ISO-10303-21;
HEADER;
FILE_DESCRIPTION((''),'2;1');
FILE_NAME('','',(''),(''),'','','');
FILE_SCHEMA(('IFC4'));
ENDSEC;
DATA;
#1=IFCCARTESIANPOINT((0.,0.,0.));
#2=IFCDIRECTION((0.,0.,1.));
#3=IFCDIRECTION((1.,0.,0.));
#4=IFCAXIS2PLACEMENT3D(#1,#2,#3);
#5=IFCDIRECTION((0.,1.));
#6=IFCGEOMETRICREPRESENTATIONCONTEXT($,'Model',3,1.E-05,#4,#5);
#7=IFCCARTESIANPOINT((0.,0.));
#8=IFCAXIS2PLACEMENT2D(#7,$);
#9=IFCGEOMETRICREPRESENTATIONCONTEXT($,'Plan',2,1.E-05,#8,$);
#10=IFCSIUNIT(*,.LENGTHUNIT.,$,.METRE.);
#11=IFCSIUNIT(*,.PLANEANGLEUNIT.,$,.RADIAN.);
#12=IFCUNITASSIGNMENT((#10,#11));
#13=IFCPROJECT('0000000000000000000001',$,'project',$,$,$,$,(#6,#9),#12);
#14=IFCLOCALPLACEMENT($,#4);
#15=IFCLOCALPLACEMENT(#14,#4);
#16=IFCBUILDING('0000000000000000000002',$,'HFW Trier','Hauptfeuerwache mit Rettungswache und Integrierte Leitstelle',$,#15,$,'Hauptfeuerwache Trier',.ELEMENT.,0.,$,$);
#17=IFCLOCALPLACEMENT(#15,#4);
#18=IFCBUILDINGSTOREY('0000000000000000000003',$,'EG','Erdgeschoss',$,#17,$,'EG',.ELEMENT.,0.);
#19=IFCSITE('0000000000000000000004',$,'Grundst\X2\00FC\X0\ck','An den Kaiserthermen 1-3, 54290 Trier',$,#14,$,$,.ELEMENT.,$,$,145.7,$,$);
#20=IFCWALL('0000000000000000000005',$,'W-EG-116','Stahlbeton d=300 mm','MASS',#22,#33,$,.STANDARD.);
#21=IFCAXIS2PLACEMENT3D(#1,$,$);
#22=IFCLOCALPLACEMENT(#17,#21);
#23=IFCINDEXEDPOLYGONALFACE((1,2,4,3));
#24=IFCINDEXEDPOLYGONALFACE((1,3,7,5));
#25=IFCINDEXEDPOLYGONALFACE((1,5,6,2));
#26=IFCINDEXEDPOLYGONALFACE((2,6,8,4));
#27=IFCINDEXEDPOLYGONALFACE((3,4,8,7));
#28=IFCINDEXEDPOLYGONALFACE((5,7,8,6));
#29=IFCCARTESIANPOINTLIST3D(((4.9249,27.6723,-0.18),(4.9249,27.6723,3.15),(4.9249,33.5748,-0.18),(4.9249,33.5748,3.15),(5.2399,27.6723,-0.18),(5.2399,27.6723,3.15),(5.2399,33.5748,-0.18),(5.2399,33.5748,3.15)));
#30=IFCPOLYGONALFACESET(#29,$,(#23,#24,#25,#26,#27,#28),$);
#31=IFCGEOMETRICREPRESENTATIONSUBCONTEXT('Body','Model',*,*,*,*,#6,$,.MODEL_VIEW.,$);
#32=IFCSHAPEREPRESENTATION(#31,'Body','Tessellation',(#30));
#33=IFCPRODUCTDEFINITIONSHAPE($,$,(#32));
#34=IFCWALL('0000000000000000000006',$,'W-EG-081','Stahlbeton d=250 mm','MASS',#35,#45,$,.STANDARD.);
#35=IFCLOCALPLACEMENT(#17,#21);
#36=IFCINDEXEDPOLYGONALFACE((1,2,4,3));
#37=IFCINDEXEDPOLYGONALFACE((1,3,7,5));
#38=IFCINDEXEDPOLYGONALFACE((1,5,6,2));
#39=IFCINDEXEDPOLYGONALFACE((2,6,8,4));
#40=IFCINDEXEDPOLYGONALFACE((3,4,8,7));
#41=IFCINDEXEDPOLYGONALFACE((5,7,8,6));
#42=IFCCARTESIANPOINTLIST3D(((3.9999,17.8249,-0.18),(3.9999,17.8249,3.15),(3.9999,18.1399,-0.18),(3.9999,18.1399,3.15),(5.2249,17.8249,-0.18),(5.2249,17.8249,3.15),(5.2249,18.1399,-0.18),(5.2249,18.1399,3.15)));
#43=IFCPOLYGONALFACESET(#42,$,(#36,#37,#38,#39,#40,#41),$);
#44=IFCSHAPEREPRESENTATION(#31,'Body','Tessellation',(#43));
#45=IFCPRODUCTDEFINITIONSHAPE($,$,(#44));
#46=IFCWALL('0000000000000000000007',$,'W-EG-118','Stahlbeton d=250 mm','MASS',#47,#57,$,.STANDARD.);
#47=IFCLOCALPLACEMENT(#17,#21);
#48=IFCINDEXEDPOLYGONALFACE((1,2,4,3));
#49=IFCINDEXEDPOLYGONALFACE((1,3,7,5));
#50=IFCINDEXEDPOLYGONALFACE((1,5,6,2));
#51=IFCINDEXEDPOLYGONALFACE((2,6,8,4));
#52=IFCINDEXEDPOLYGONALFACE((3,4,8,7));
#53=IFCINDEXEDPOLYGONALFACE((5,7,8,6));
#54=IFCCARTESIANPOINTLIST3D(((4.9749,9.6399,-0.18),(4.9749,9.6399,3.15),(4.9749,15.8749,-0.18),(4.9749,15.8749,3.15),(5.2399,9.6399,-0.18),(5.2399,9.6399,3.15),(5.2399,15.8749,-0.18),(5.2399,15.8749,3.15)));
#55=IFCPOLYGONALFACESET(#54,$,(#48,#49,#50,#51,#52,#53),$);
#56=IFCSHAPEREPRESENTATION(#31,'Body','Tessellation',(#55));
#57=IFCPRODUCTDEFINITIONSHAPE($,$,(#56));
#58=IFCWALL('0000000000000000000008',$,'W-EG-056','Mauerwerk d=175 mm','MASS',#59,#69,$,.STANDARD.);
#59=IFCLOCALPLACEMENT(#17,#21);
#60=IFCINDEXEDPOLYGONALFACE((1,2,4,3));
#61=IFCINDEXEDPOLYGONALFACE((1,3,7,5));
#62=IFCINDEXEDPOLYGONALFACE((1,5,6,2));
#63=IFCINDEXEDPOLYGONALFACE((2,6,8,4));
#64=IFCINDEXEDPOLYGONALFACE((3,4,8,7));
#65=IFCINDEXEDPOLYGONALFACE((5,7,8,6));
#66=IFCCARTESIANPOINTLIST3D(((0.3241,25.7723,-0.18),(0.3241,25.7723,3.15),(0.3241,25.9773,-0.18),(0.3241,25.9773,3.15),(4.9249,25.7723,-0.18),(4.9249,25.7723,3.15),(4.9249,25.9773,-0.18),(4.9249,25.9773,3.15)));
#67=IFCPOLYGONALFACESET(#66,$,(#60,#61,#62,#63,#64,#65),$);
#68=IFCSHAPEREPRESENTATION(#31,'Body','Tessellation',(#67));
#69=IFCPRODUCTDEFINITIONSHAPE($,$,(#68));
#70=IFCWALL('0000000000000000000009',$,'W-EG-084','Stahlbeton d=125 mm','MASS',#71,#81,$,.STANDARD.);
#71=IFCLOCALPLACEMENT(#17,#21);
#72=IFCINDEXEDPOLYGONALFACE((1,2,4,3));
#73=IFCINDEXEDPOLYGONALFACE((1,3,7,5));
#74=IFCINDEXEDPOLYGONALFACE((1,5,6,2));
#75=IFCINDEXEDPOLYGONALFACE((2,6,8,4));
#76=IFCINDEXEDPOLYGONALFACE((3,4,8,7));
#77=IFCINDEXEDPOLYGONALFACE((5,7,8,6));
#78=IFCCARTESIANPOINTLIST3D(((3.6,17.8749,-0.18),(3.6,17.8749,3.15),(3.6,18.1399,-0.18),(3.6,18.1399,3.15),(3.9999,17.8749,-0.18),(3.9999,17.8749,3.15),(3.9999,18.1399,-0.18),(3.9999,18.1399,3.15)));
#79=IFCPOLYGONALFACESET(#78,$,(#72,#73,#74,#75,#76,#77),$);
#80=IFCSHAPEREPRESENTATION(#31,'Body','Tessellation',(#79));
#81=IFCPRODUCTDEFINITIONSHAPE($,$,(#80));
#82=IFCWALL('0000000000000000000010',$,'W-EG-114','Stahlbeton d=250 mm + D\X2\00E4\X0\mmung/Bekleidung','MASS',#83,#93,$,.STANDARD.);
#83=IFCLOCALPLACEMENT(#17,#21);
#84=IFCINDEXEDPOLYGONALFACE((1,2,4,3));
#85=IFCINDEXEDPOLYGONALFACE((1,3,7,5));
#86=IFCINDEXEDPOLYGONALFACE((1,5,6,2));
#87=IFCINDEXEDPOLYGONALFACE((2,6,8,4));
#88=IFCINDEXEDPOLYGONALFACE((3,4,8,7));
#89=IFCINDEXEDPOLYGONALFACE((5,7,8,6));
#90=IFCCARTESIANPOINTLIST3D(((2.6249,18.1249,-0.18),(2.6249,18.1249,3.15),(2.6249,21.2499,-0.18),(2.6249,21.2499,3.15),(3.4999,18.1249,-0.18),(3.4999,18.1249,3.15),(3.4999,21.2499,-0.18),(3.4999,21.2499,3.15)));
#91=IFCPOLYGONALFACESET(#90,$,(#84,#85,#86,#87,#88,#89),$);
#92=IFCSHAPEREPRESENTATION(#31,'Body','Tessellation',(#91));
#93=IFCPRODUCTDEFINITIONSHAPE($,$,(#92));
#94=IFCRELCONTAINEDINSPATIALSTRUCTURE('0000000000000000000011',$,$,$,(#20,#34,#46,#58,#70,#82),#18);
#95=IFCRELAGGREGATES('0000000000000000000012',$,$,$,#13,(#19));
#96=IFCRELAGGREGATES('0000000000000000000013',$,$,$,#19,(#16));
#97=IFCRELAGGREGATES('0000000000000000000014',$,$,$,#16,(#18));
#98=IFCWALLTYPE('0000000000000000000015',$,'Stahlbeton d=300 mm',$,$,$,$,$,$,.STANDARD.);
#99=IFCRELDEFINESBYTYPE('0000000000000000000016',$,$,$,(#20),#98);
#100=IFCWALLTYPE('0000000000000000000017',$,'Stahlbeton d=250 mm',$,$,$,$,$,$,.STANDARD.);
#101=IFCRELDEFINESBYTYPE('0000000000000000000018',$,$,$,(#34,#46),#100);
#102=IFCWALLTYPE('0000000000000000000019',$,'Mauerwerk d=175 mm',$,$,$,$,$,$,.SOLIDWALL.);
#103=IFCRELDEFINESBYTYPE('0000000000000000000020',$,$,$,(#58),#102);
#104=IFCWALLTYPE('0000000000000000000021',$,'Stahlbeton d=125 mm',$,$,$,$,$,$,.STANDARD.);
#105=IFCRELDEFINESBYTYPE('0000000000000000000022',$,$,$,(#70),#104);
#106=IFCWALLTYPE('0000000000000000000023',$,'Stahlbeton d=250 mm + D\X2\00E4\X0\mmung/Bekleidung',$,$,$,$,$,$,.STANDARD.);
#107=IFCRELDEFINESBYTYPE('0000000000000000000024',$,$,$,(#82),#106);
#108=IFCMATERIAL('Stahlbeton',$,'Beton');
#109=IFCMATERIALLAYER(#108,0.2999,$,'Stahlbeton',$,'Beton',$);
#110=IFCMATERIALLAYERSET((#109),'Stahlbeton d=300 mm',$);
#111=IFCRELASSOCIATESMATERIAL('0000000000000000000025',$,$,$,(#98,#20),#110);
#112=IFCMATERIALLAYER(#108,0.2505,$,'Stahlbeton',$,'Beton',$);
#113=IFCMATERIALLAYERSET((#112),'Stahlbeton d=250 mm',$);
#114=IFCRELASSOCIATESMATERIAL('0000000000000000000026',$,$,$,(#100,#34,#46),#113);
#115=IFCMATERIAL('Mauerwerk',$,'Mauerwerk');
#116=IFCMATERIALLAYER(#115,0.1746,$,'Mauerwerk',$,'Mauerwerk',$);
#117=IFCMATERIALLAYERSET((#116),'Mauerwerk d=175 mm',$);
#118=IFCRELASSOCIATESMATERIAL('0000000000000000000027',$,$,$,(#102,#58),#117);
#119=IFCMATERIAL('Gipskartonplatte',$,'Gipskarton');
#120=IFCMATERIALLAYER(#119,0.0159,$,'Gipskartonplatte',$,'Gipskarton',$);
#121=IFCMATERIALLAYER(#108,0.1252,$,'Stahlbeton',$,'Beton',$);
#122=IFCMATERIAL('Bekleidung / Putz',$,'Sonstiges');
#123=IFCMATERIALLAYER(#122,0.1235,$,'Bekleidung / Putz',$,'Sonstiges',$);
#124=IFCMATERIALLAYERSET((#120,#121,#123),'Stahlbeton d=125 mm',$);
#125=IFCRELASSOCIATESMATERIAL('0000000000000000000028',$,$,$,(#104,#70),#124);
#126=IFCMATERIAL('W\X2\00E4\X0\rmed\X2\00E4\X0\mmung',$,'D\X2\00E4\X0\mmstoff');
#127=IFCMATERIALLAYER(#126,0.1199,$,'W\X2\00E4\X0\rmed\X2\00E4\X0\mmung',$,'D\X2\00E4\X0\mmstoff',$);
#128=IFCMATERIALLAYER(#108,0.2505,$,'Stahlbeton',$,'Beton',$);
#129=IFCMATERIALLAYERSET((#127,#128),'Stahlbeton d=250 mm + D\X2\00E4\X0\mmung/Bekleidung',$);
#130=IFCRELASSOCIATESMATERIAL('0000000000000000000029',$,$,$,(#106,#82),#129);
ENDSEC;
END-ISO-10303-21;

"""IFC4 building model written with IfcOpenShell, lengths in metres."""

from ifc_helpers import new_model, si_unit, direction, frame, frame_2d, origin_with_axes, origin_2d, place, context, subcontext, project, spatial, rectangle, extrude, material, layer, layer_set, layer_usage, type_object, element, save


model = new_model("IFC4")

# Units and contexts
model_context = context("Model", 3, precision=1e-05, world=origin_with_axes(), true_north=direction((0.0, 1.0)))
plan_context = context("Plan", 2, precision=1e-05, world=origin_2d())
body_context = subcontext(model_context, "Body", "Model", "MODEL_VIEW")
ifc_project = project(units=[si_unit("LENGTHUNIT", "METRE"), si_unit("PLANEANGLEUNIT", "RADIAN")], contexts=[model_context, plan_context])

# Site, building, storey
site_placement = place(None, origin_with_axes())
site = spatial("IfcSite", under=ifc_project, at=site_placement, Name="Grundstück", Description="An den Kaiserthermen 1-3, 54290 Trier", CompositionType="ELEMENT", RefElevation=145.7)
building_placement = place(site_placement, origin_with_axes())
building = spatial("IfcBuilding", under=site, at=building_placement, Name="HFW Trier", Description="Hauptfeuerwache mit Rettungswache und Integrierte Leitstelle", LongName="Hauptfeuerwache Trier", CompositionType="ELEMENT", ElevationOfRefHeight=0.0)
storey_placement = place(building_placement, origin_with_axes())
storey = spatial("IfcBuildingStorey", under=building, at=storey_placement, Name="EG", Description="Erdgeschoss", LongName="EG", CompositionType="ELEMENT", Elevation=0.0)

# Shared definitions
ifc_material_1 = material(Name="Stahlbeton", Category="Beton")
ifc_layer_1 = layer(ifc_material_1, 0.2999, Name="Stahlbeton", Category="Beton")
ifc_layer_set_1 = layer_set([ifc_layer_1], Name="Stahlbeton d=300 mm")
wall_type_1 = type_object("IfcWallType", Name="Stahlbeton d=300 mm", PredefinedType="STANDARD", material=ifc_layer_set_1)

# Walls
ifc_layer_usage_1 = layer_usage(ifc_layer_set_1, "AXIS2", "POSITIVE", -0.1575)
wall_1_placement = place(storey_placement, frame((5.0824, 33.5748, -0.18), z_axis=(0.0, 0.0, 1.0), x_axis=(0.0, -1.0, 0.0)))
element("IfcWall", 1, at=wall_1_placement, inside=storey, type_object=wall_type_1, material=ifc_layer_usage_1, Name="W-EG-116", Description="Stahlbeton d=300 mm", ObjectType="MASS", PredefinedType="STANDARD", context=body_context, shape_type="SweptSolid", body=[
    extrude(rectangle(XDim=5.9025, YDim=0.315, at=frame_2d((2.9513, 0.0))), origin_with_axes(), (0.0, 0.0, 1.0), 3.33),
])
ifc_layer_2 = layer(ifc_material_1, 0.2505, Name="Stahlbeton", Category="Beton")
ifc_layer_set_2 = layer_set([ifc_layer_2], Name="Stahlbeton d=250 mm")
ifc_layer_usage_2 = layer_usage(ifc_layer_set_2, "AXIS2", "POSITIVE", -0.1575)
wall_type_2 = type_object("IfcWallType", Name="Stahlbeton d=250 mm", PredefinedType="STANDARD", material=ifc_layer_set_2)
wall_2_placement = place(storey_placement, frame((3.9999, 17.9824, -0.18), z_axis=(0.0, 0.0, 1.0), x_axis=(1.0, 0.0, 0.0)))
element("IfcWall", 2, at=wall_2_placement, inside=storey, type_object=wall_type_2, material=ifc_layer_usage_2, Name="W-EG-081", Description="Stahlbeton d=250 mm", ObjectType="MASS", PredefinedType="STANDARD", context=body_context, shape_type="SweptSolid", body=[
    extrude(rectangle(XDim=1.225, YDim=0.315, at=frame_2d((0.6125, 0.0))), origin_with_axes(), (0.0, 0.0, 1.0), 3.33),
])
ifc_layer_usage_3 = layer_usage(ifc_layer_set_2, "AXIS2", "POSITIVE", -0.1325)
wall_3_placement = place(storey_placement, frame((5.1074, 15.8749, -0.18), z_axis=(0.0, 0.0, 1.0), x_axis=(0.0, -1.0, 0.0)))
element("IfcWall", 3, at=wall_3_placement, inside=storey, type_object=wall_type_2, material=ifc_layer_usage_3, Name="W-EG-118", Description="Stahlbeton d=250 mm", ObjectType="MASS", PredefinedType="STANDARD", context=body_context, shape_type="SweptSolid", body=[
    extrude(rectangle(XDim=6.235, YDim=0.265, at=frame_2d((3.1175, 0.0))), origin_with_axes(), (0.0, 0.0, 1.0), 3.33),
])
ifc_material_2 = material(Name="Mauerwerk", Category="Mauerwerk")
ifc_layer_3 = layer(ifc_material_2, 0.1746, Name="Mauerwerk", Category="Mauerwerk")
ifc_layer_set_3 = layer_set([ifc_layer_3], Name="Mauerwerk d=175 mm")
ifc_layer_usage_4 = layer_usage(ifc_layer_set_3, "AXIS2", "POSITIVE", -0.1025)
wall_type_3 = type_object("IfcWallType", Name="Mauerwerk d=175 mm", PredefinedType="SOLIDWALL", material=ifc_layer_set_3)
wall_4_placement = place(storey_placement, frame((0.3241, 25.8748, -0.18), z_axis=(0.0, 0.0, 1.0), x_axis=(1.0, 0.0, 0.0)))
element("IfcWall", 4, at=wall_4_placement, inside=storey, type_object=wall_type_3, material=ifc_layer_usage_4, Name="W-EG-056", Description="Mauerwerk d=175 mm", ObjectType="MASS", PredefinedType="STANDARD", context=body_context, shape_type="SweptSolid", body=[
    extrude(rectangle(XDim=4.6008, YDim=0.205, at=frame_2d((2.3004, 0.0))), origin_with_axes(), (0.0, 0.0, 1.0), 3.33),
])
ifc_material_3 = material(Name="Gipskartonplatte", Category="Gipskarton")
ifc_layer_4 = layer(ifc_material_3, 0.0159, Name="Gipskartonplatte", Category="Gipskarton")
ifc_layer_5 = layer(ifc_material_1, 0.1252, Name="Stahlbeton", Category="Beton")
ifc_material_4 = material(Name="Bekleidung / Putz", Category="Sonstiges")
ifc_layer_6 = layer(ifc_material_4, 0.1235, Name="Bekleidung / Putz", Category="Sonstiges")
ifc_layer_set_4 = layer_set([ifc_layer_4, ifc_layer_5, ifc_layer_6], Name="Stahlbeton d=125 mm")
ifc_layer_usage_5 = layer_usage(ifc_layer_set_4, "AXIS2", "POSITIVE", -0.1325)
wall_type_4 = type_object("IfcWallType", Name="Stahlbeton d=125 mm", PredefinedType="STANDARD", material=ifc_layer_set_4)
wall_5_placement = place(storey_placement, frame((3.6, 18.0074, -0.18), z_axis=(0.0, 0.0, 1.0), x_axis=(1.0, 0.0, 0.0)))
element("IfcWall", 5, at=wall_5_placement, inside=storey, type_object=wall_type_4, material=ifc_layer_usage_5, Name="W-EG-084", Description="Stahlbeton d=125 mm", ObjectType="MASS", PredefinedType="STANDARD", context=body_context, shape_type="SweptSolid", body=[
    extrude(rectangle(XDim=0.3999, YDim=0.265, at=frame_2d((0.1999, 0.0))), origin_with_axes(), (0.0, 0.0, 1.0), 3.33),
])
ifc_material_5 = material(Name="Wärmedämmung", Category="Dämmstoff")
ifc_layer_7 = layer(ifc_material_5, 0.1199, Name="Wärmedämmung", Category="Dämmstoff")
ifc_layer_8 = layer(ifc_material_1, 0.2505, Name="Stahlbeton", Category="Beton")
ifc_layer_set_5 = layer_set([ifc_layer_7, ifc_layer_8], Name="Stahlbeton d=250 mm + Dämmung/Bekleidung")
ifc_layer_usage_6 = layer_usage(ifc_layer_set_5, "AXIS2", "POSITIVE", -0.4375)
wall_type_5 = type_object("IfcWallType", Name="Stahlbeton d=250 mm + Dämmung/Bekleidung", PredefinedType="STANDARD", material=ifc_layer_set_5)
wall_6_placement = place(storey_placement, frame((3.0624, 21.2499, -0.18), z_axis=(0.0, 0.0, 1.0), x_axis=(0.0, -1.0, 0.0)))
element("IfcWall", 6, at=wall_6_placement, inside=storey, type_object=wall_type_5, material=ifc_layer_usage_6, Name="W-EG-114", Description="Stahlbeton d=250 mm + Dämmung/Bekleidung", ObjectType="MASS", PredefinedType="STANDARD", context=body_context, shape_type="SweptSolid", body=[
    extrude(rectangle(XDim=3.125, YDim=0.875, at=frame_2d((1.5625, 0.0))), origin_with_axes(), (0.0, 0.0, 1.0), 3.33),
])

save(model, "model.ifc")
